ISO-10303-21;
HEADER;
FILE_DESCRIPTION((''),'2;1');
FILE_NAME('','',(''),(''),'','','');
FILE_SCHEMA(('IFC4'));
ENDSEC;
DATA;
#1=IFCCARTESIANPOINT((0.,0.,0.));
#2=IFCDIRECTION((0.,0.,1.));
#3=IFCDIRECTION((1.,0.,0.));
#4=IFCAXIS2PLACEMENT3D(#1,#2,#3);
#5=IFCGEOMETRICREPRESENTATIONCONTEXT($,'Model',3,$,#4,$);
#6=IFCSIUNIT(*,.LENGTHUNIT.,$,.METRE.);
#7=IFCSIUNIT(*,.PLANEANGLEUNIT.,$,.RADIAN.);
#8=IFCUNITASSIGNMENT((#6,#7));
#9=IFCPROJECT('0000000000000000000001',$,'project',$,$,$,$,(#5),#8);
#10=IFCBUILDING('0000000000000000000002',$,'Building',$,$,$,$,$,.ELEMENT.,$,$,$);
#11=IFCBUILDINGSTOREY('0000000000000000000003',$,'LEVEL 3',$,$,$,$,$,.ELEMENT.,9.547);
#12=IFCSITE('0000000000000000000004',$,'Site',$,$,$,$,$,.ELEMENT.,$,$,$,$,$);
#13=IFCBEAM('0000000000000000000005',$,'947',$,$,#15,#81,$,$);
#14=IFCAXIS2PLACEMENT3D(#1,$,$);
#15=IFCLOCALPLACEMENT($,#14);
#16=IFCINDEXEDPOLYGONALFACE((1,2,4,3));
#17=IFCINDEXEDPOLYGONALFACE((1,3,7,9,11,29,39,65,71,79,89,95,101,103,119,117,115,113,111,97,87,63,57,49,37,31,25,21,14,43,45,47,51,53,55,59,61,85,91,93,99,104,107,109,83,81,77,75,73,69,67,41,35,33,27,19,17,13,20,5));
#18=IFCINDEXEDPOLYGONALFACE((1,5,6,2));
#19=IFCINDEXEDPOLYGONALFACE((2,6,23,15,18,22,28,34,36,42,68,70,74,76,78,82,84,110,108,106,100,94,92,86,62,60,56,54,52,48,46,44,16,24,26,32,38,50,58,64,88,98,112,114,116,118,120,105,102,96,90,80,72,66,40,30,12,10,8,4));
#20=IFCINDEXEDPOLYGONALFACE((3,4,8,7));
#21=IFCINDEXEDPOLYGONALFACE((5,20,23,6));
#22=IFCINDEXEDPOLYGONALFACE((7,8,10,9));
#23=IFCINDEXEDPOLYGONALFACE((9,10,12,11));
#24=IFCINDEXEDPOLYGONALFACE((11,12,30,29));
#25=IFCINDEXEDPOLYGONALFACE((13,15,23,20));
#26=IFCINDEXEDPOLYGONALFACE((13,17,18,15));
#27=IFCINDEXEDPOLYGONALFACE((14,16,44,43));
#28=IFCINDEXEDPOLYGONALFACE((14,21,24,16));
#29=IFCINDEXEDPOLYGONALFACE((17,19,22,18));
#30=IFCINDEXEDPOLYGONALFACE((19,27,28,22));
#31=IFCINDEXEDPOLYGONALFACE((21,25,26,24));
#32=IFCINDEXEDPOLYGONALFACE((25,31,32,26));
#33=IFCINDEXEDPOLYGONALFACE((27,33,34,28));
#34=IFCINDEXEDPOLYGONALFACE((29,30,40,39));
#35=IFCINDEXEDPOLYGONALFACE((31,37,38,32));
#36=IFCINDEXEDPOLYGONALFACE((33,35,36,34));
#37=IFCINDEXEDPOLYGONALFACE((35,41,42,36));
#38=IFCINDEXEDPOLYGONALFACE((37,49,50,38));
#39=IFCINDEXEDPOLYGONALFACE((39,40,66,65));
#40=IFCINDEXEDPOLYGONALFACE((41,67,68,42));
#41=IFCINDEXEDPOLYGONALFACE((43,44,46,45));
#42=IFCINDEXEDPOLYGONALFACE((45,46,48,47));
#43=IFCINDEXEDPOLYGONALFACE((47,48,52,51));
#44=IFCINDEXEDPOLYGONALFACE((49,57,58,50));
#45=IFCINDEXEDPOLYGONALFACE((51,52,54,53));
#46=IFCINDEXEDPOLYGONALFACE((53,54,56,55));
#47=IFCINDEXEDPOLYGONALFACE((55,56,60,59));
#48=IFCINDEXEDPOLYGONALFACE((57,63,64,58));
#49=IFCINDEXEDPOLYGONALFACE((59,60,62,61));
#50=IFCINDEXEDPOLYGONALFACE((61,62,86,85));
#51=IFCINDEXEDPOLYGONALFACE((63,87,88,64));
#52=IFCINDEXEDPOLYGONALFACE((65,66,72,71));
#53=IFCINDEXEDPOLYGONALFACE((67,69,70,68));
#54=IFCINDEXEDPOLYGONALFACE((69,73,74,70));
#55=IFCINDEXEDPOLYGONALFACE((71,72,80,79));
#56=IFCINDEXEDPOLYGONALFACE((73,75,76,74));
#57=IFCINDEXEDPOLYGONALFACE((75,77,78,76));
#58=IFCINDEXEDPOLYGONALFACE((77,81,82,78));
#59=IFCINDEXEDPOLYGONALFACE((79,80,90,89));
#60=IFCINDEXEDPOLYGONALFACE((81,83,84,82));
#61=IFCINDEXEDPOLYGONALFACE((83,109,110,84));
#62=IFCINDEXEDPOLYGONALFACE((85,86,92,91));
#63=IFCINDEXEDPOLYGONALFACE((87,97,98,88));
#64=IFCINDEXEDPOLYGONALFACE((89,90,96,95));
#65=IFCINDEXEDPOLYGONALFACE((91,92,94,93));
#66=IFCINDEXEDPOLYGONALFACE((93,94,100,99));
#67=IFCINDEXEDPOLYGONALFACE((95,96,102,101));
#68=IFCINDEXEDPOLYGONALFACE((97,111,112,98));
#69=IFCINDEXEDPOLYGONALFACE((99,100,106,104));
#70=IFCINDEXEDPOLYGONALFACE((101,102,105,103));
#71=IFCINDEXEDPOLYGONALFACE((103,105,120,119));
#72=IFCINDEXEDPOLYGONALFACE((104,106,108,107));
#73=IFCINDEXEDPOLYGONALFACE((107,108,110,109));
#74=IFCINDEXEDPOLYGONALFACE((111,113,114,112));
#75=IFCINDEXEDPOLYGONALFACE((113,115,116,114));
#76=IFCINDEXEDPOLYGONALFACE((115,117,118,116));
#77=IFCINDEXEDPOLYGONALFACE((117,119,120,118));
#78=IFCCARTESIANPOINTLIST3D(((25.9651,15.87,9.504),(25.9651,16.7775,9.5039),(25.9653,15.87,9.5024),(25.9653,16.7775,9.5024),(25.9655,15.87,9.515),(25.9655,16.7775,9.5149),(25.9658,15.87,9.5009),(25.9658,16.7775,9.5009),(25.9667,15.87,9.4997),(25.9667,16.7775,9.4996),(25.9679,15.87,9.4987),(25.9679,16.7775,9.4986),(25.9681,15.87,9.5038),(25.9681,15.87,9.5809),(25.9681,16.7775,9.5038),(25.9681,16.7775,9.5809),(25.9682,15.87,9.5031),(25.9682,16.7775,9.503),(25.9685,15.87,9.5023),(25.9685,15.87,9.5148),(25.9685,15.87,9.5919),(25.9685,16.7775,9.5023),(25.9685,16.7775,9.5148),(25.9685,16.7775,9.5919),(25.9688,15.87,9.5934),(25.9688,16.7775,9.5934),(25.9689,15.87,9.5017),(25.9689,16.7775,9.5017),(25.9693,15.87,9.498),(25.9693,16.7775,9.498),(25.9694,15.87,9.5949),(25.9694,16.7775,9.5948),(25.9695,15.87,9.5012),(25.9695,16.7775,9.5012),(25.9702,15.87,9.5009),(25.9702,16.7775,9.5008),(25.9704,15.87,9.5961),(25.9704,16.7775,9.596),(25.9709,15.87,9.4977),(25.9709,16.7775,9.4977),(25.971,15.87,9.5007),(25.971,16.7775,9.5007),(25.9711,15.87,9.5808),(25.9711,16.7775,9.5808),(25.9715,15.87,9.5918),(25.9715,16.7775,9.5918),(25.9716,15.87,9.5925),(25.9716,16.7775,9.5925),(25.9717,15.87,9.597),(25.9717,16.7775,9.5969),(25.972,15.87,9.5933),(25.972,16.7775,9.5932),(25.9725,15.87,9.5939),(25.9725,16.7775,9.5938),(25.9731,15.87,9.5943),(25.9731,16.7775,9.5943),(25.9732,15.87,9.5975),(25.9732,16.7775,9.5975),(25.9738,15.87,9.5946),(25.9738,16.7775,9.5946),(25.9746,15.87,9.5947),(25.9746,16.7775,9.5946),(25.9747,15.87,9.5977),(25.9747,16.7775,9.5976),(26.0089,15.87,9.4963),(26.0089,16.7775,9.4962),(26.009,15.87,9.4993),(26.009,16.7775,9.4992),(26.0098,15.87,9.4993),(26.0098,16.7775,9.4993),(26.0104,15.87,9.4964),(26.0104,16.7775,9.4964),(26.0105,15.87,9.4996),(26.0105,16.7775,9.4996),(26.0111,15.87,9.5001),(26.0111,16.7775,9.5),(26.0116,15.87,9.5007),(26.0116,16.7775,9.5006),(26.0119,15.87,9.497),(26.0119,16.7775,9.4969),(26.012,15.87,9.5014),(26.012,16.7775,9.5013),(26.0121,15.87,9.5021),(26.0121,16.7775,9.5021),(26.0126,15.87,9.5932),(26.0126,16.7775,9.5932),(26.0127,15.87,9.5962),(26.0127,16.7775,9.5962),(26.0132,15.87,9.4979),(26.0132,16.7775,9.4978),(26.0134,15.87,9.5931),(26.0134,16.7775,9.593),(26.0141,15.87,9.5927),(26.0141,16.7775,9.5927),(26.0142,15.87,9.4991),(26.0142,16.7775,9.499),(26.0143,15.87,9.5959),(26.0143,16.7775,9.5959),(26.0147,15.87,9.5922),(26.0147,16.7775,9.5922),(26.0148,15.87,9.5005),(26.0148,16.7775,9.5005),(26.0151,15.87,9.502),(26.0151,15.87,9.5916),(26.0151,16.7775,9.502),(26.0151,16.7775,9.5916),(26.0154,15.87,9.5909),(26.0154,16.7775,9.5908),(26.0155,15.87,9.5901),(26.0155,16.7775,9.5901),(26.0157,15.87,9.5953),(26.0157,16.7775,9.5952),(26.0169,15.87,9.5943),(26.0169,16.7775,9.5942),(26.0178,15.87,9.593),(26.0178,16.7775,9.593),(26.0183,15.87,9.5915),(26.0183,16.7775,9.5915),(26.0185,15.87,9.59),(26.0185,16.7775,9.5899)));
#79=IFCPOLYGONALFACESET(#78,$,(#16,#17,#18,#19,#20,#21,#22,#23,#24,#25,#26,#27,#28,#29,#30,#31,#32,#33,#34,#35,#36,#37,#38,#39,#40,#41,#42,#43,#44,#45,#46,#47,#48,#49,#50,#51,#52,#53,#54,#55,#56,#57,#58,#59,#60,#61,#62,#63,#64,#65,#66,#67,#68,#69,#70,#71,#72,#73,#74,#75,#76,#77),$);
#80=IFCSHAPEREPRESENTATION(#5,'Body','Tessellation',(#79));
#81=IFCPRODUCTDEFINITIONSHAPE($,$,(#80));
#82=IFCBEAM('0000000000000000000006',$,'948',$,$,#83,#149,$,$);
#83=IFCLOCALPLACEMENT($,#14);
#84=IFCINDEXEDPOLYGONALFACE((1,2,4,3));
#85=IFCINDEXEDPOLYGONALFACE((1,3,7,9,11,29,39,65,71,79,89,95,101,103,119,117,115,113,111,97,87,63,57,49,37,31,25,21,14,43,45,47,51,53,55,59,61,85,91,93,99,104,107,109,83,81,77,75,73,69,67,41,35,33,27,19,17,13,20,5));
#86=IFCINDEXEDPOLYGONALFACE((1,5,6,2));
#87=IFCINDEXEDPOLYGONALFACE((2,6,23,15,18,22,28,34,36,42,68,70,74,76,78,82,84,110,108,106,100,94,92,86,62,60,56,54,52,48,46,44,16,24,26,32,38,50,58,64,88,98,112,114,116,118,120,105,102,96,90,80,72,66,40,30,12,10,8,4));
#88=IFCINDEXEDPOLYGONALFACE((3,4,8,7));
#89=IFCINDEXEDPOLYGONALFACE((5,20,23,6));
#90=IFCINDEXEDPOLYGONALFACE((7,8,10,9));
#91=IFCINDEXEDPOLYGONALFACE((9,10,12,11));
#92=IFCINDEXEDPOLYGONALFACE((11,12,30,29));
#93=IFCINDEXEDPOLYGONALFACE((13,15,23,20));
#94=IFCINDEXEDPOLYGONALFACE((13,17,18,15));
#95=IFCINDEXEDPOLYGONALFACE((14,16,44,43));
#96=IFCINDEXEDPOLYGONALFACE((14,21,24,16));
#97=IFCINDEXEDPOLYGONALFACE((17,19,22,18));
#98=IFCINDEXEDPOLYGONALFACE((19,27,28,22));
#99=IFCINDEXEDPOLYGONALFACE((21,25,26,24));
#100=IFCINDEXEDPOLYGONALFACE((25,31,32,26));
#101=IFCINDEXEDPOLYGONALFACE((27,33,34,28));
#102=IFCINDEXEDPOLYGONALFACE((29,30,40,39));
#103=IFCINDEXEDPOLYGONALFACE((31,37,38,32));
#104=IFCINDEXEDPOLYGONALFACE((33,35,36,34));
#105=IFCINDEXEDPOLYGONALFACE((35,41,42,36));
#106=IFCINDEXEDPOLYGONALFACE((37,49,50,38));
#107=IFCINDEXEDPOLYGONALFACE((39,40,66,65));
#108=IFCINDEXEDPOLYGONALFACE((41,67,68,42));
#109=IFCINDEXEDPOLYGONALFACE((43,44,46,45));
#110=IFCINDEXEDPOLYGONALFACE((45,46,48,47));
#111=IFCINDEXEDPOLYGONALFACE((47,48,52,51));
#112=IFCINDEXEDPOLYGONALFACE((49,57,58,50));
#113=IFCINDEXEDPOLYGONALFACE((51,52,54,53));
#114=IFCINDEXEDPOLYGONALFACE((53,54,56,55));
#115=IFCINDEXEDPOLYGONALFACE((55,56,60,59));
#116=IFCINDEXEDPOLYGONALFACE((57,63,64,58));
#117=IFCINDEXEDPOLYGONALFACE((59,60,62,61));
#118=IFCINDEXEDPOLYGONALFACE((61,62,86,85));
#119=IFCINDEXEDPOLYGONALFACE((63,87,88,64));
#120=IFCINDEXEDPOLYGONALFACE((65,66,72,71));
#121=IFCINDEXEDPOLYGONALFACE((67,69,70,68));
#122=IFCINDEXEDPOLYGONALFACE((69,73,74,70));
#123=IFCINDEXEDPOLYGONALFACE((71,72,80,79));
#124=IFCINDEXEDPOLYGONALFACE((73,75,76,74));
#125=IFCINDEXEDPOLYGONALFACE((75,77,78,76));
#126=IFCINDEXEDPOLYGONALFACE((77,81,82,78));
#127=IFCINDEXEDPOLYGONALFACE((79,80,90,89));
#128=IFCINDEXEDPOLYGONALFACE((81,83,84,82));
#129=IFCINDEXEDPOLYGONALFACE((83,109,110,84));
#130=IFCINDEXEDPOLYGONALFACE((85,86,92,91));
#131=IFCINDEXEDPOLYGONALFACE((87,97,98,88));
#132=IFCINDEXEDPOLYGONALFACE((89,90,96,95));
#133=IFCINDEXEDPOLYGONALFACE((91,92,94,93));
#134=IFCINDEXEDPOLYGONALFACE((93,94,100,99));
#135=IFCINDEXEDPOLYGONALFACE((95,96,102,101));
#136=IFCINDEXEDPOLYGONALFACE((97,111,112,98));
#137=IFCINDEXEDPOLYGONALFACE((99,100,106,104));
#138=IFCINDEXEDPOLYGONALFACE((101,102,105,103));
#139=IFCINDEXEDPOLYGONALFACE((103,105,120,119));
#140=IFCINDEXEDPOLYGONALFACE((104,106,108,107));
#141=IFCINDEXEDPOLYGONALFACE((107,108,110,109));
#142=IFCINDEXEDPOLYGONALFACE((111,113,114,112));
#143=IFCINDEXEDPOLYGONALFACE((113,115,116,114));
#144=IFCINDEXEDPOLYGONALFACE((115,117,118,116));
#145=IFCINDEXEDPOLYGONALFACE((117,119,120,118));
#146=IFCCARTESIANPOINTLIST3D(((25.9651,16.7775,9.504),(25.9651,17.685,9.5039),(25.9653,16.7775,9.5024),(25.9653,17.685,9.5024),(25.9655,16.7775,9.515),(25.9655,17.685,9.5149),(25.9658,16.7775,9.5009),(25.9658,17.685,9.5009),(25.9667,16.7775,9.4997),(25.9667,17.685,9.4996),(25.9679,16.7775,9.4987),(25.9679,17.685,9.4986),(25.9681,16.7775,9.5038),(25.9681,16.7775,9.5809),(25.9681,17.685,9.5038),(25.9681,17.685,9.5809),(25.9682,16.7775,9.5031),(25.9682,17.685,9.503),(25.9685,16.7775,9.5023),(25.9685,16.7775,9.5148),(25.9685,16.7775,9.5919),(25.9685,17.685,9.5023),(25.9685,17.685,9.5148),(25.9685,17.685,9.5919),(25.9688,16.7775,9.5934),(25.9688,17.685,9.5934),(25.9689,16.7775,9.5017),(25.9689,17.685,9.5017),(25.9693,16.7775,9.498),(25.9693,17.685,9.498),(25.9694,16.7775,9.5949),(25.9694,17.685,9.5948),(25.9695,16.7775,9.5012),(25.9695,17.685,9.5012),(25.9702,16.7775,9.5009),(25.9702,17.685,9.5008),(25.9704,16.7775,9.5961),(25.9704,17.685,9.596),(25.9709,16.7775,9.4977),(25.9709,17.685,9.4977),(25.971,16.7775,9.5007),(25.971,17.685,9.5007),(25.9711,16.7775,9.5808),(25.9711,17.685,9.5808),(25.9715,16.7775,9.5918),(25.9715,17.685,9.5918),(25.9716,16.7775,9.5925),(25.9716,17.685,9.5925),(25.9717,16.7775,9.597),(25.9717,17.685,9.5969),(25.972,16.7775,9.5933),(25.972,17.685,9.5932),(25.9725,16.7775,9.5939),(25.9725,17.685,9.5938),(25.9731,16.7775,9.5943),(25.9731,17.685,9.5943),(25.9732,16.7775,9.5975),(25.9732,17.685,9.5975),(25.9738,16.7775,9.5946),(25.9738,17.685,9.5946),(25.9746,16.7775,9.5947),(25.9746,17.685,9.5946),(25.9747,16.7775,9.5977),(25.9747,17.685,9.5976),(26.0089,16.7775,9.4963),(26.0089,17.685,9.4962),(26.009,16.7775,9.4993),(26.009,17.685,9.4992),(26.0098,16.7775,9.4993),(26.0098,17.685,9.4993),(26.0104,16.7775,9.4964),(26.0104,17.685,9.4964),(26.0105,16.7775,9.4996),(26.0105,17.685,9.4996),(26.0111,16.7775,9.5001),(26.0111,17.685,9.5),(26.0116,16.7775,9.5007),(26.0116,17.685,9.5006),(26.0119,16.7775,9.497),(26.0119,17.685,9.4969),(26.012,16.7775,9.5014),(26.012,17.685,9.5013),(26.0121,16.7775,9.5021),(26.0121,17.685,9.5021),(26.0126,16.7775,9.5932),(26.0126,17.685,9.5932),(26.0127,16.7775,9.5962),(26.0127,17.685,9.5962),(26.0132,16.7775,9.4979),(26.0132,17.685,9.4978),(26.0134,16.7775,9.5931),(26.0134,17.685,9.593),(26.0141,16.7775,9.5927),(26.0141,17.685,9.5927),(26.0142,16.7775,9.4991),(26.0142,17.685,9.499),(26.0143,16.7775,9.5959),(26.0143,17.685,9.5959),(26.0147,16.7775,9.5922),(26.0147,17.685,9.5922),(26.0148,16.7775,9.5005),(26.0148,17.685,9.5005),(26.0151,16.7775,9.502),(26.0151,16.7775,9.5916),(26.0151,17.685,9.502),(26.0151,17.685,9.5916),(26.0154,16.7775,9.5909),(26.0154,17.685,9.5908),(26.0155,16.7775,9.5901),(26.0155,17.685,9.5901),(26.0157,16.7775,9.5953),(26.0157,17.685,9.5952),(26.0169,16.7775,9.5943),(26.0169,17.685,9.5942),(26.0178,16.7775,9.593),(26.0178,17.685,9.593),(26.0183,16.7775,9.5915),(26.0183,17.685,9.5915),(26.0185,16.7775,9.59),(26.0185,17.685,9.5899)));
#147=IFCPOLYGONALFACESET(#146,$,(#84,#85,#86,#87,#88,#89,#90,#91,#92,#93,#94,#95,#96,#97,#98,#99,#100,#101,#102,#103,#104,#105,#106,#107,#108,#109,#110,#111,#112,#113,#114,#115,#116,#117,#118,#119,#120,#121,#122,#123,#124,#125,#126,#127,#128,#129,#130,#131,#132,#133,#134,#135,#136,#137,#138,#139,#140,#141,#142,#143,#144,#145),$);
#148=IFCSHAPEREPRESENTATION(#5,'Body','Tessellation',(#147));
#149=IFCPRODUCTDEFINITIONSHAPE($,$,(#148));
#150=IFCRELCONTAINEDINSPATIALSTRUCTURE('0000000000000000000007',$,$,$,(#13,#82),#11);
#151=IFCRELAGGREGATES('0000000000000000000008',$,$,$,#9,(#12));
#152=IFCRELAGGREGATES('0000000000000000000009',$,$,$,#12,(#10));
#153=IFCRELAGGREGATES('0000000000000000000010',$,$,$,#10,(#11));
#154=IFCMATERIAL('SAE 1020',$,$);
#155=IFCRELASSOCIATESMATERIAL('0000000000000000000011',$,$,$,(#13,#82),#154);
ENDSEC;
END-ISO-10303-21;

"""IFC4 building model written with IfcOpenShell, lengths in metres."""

from ifc_helpers import new_model, si_unit, frame, origin_with_axes, origin_2d_with_axis, place, context, project, spatial, c_section, extrude, material, material_profile, profile_set, profile_usage, element, save


model = new_model("IFC4")

# Units and contexts
model_context = context("Model", 3, world=origin_with_axes())
ifc_project = project(units=[si_unit("LENGTHUNIT", "METRE"), si_unit("PLANEANGLEUNIT", "RADIAN")], contexts=[model_context])

# Site, building, storey
site = spatial("IfcSite", under=ifc_project, Name="Site", CompositionType="ELEMENT")
building = spatial("IfcBuilding", under=site, Name="Building", CompositionType="ELEMENT")
storey = spatial("IfcBuildingStorey", under=building, Name="LEVEL 3", CompositionType="ELEMENT", Elevation=9.547)

# Beams
ifc_material = material(Name="SAE 1020")
ifc_material_profile_1 = material_profile(ifc_material, c_section(Depth=0.1, Width=0.05, WallThickness=0.003, Girth=0.017, InternalFilletRadius=0.003, at=origin_2d_with_axis()))
ifc_profile_set_1 = profile_set([ifc_material_profile_1])
ifc_profile_usage_1 = profile_usage(ifc_profile_set_1, cardinal=10)
beam_1_placement = place(None, frame((25.9918, 15.87, 9.547), z_axis=(0.0, 1.0, -0.00003), x_axis=(-0.999256, 0.000001, 0.038562)))
element("IfcBeam", 1, at=beam_1_placement, inside=storey, material=ifc_profile_usage_1, Name="947", context=model_context, shape_type="SweptSolid", body=[
    extrude(c_section(Depth=0.1, Width=0.05, WallThickness=0.003, Girth=0.017, InternalFilletRadius=0.003, at=origin_2d_with_axis()), origin_with_axes(), (0.0, 0.0, 1.0), 0.9075),
])
ifc_material_profile_2 = material_profile(ifc_material, c_section(Depth=0.1, Width=0.05, WallThickness=0.003, Girth=0.017, InternalFilletRadius=0.003, at=origin_2d_with_axis()))
ifc_profile_set_2 = profile_set([ifc_material_profile_2])
ifc_profile_usage_2 = profile_usage(ifc_profile_set_2, cardinal=10)
beam_2_placement = place(None, frame((25.9918, 16.7775, 9.547), z_axis=(0.0, 1.0, -0.00003), x_axis=(-0.999256, 0.000001, 0.038562)))
element("IfcBeam", 2, at=beam_2_placement, inside=storey, material=ifc_profile_usage_2, Name="948", context=model_context, shape_type="SweptSolid", body=[
    extrude(c_section(Depth=0.1, Width=0.05, WallThickness=0.003, Girth=0.017, InternalFilletRadius=0.003, at=origin_2d_with_axis()), origin_with_axes(), (0.0, 0.0, 1.0), 0.9075),
])

save(model, "model.ifc")
